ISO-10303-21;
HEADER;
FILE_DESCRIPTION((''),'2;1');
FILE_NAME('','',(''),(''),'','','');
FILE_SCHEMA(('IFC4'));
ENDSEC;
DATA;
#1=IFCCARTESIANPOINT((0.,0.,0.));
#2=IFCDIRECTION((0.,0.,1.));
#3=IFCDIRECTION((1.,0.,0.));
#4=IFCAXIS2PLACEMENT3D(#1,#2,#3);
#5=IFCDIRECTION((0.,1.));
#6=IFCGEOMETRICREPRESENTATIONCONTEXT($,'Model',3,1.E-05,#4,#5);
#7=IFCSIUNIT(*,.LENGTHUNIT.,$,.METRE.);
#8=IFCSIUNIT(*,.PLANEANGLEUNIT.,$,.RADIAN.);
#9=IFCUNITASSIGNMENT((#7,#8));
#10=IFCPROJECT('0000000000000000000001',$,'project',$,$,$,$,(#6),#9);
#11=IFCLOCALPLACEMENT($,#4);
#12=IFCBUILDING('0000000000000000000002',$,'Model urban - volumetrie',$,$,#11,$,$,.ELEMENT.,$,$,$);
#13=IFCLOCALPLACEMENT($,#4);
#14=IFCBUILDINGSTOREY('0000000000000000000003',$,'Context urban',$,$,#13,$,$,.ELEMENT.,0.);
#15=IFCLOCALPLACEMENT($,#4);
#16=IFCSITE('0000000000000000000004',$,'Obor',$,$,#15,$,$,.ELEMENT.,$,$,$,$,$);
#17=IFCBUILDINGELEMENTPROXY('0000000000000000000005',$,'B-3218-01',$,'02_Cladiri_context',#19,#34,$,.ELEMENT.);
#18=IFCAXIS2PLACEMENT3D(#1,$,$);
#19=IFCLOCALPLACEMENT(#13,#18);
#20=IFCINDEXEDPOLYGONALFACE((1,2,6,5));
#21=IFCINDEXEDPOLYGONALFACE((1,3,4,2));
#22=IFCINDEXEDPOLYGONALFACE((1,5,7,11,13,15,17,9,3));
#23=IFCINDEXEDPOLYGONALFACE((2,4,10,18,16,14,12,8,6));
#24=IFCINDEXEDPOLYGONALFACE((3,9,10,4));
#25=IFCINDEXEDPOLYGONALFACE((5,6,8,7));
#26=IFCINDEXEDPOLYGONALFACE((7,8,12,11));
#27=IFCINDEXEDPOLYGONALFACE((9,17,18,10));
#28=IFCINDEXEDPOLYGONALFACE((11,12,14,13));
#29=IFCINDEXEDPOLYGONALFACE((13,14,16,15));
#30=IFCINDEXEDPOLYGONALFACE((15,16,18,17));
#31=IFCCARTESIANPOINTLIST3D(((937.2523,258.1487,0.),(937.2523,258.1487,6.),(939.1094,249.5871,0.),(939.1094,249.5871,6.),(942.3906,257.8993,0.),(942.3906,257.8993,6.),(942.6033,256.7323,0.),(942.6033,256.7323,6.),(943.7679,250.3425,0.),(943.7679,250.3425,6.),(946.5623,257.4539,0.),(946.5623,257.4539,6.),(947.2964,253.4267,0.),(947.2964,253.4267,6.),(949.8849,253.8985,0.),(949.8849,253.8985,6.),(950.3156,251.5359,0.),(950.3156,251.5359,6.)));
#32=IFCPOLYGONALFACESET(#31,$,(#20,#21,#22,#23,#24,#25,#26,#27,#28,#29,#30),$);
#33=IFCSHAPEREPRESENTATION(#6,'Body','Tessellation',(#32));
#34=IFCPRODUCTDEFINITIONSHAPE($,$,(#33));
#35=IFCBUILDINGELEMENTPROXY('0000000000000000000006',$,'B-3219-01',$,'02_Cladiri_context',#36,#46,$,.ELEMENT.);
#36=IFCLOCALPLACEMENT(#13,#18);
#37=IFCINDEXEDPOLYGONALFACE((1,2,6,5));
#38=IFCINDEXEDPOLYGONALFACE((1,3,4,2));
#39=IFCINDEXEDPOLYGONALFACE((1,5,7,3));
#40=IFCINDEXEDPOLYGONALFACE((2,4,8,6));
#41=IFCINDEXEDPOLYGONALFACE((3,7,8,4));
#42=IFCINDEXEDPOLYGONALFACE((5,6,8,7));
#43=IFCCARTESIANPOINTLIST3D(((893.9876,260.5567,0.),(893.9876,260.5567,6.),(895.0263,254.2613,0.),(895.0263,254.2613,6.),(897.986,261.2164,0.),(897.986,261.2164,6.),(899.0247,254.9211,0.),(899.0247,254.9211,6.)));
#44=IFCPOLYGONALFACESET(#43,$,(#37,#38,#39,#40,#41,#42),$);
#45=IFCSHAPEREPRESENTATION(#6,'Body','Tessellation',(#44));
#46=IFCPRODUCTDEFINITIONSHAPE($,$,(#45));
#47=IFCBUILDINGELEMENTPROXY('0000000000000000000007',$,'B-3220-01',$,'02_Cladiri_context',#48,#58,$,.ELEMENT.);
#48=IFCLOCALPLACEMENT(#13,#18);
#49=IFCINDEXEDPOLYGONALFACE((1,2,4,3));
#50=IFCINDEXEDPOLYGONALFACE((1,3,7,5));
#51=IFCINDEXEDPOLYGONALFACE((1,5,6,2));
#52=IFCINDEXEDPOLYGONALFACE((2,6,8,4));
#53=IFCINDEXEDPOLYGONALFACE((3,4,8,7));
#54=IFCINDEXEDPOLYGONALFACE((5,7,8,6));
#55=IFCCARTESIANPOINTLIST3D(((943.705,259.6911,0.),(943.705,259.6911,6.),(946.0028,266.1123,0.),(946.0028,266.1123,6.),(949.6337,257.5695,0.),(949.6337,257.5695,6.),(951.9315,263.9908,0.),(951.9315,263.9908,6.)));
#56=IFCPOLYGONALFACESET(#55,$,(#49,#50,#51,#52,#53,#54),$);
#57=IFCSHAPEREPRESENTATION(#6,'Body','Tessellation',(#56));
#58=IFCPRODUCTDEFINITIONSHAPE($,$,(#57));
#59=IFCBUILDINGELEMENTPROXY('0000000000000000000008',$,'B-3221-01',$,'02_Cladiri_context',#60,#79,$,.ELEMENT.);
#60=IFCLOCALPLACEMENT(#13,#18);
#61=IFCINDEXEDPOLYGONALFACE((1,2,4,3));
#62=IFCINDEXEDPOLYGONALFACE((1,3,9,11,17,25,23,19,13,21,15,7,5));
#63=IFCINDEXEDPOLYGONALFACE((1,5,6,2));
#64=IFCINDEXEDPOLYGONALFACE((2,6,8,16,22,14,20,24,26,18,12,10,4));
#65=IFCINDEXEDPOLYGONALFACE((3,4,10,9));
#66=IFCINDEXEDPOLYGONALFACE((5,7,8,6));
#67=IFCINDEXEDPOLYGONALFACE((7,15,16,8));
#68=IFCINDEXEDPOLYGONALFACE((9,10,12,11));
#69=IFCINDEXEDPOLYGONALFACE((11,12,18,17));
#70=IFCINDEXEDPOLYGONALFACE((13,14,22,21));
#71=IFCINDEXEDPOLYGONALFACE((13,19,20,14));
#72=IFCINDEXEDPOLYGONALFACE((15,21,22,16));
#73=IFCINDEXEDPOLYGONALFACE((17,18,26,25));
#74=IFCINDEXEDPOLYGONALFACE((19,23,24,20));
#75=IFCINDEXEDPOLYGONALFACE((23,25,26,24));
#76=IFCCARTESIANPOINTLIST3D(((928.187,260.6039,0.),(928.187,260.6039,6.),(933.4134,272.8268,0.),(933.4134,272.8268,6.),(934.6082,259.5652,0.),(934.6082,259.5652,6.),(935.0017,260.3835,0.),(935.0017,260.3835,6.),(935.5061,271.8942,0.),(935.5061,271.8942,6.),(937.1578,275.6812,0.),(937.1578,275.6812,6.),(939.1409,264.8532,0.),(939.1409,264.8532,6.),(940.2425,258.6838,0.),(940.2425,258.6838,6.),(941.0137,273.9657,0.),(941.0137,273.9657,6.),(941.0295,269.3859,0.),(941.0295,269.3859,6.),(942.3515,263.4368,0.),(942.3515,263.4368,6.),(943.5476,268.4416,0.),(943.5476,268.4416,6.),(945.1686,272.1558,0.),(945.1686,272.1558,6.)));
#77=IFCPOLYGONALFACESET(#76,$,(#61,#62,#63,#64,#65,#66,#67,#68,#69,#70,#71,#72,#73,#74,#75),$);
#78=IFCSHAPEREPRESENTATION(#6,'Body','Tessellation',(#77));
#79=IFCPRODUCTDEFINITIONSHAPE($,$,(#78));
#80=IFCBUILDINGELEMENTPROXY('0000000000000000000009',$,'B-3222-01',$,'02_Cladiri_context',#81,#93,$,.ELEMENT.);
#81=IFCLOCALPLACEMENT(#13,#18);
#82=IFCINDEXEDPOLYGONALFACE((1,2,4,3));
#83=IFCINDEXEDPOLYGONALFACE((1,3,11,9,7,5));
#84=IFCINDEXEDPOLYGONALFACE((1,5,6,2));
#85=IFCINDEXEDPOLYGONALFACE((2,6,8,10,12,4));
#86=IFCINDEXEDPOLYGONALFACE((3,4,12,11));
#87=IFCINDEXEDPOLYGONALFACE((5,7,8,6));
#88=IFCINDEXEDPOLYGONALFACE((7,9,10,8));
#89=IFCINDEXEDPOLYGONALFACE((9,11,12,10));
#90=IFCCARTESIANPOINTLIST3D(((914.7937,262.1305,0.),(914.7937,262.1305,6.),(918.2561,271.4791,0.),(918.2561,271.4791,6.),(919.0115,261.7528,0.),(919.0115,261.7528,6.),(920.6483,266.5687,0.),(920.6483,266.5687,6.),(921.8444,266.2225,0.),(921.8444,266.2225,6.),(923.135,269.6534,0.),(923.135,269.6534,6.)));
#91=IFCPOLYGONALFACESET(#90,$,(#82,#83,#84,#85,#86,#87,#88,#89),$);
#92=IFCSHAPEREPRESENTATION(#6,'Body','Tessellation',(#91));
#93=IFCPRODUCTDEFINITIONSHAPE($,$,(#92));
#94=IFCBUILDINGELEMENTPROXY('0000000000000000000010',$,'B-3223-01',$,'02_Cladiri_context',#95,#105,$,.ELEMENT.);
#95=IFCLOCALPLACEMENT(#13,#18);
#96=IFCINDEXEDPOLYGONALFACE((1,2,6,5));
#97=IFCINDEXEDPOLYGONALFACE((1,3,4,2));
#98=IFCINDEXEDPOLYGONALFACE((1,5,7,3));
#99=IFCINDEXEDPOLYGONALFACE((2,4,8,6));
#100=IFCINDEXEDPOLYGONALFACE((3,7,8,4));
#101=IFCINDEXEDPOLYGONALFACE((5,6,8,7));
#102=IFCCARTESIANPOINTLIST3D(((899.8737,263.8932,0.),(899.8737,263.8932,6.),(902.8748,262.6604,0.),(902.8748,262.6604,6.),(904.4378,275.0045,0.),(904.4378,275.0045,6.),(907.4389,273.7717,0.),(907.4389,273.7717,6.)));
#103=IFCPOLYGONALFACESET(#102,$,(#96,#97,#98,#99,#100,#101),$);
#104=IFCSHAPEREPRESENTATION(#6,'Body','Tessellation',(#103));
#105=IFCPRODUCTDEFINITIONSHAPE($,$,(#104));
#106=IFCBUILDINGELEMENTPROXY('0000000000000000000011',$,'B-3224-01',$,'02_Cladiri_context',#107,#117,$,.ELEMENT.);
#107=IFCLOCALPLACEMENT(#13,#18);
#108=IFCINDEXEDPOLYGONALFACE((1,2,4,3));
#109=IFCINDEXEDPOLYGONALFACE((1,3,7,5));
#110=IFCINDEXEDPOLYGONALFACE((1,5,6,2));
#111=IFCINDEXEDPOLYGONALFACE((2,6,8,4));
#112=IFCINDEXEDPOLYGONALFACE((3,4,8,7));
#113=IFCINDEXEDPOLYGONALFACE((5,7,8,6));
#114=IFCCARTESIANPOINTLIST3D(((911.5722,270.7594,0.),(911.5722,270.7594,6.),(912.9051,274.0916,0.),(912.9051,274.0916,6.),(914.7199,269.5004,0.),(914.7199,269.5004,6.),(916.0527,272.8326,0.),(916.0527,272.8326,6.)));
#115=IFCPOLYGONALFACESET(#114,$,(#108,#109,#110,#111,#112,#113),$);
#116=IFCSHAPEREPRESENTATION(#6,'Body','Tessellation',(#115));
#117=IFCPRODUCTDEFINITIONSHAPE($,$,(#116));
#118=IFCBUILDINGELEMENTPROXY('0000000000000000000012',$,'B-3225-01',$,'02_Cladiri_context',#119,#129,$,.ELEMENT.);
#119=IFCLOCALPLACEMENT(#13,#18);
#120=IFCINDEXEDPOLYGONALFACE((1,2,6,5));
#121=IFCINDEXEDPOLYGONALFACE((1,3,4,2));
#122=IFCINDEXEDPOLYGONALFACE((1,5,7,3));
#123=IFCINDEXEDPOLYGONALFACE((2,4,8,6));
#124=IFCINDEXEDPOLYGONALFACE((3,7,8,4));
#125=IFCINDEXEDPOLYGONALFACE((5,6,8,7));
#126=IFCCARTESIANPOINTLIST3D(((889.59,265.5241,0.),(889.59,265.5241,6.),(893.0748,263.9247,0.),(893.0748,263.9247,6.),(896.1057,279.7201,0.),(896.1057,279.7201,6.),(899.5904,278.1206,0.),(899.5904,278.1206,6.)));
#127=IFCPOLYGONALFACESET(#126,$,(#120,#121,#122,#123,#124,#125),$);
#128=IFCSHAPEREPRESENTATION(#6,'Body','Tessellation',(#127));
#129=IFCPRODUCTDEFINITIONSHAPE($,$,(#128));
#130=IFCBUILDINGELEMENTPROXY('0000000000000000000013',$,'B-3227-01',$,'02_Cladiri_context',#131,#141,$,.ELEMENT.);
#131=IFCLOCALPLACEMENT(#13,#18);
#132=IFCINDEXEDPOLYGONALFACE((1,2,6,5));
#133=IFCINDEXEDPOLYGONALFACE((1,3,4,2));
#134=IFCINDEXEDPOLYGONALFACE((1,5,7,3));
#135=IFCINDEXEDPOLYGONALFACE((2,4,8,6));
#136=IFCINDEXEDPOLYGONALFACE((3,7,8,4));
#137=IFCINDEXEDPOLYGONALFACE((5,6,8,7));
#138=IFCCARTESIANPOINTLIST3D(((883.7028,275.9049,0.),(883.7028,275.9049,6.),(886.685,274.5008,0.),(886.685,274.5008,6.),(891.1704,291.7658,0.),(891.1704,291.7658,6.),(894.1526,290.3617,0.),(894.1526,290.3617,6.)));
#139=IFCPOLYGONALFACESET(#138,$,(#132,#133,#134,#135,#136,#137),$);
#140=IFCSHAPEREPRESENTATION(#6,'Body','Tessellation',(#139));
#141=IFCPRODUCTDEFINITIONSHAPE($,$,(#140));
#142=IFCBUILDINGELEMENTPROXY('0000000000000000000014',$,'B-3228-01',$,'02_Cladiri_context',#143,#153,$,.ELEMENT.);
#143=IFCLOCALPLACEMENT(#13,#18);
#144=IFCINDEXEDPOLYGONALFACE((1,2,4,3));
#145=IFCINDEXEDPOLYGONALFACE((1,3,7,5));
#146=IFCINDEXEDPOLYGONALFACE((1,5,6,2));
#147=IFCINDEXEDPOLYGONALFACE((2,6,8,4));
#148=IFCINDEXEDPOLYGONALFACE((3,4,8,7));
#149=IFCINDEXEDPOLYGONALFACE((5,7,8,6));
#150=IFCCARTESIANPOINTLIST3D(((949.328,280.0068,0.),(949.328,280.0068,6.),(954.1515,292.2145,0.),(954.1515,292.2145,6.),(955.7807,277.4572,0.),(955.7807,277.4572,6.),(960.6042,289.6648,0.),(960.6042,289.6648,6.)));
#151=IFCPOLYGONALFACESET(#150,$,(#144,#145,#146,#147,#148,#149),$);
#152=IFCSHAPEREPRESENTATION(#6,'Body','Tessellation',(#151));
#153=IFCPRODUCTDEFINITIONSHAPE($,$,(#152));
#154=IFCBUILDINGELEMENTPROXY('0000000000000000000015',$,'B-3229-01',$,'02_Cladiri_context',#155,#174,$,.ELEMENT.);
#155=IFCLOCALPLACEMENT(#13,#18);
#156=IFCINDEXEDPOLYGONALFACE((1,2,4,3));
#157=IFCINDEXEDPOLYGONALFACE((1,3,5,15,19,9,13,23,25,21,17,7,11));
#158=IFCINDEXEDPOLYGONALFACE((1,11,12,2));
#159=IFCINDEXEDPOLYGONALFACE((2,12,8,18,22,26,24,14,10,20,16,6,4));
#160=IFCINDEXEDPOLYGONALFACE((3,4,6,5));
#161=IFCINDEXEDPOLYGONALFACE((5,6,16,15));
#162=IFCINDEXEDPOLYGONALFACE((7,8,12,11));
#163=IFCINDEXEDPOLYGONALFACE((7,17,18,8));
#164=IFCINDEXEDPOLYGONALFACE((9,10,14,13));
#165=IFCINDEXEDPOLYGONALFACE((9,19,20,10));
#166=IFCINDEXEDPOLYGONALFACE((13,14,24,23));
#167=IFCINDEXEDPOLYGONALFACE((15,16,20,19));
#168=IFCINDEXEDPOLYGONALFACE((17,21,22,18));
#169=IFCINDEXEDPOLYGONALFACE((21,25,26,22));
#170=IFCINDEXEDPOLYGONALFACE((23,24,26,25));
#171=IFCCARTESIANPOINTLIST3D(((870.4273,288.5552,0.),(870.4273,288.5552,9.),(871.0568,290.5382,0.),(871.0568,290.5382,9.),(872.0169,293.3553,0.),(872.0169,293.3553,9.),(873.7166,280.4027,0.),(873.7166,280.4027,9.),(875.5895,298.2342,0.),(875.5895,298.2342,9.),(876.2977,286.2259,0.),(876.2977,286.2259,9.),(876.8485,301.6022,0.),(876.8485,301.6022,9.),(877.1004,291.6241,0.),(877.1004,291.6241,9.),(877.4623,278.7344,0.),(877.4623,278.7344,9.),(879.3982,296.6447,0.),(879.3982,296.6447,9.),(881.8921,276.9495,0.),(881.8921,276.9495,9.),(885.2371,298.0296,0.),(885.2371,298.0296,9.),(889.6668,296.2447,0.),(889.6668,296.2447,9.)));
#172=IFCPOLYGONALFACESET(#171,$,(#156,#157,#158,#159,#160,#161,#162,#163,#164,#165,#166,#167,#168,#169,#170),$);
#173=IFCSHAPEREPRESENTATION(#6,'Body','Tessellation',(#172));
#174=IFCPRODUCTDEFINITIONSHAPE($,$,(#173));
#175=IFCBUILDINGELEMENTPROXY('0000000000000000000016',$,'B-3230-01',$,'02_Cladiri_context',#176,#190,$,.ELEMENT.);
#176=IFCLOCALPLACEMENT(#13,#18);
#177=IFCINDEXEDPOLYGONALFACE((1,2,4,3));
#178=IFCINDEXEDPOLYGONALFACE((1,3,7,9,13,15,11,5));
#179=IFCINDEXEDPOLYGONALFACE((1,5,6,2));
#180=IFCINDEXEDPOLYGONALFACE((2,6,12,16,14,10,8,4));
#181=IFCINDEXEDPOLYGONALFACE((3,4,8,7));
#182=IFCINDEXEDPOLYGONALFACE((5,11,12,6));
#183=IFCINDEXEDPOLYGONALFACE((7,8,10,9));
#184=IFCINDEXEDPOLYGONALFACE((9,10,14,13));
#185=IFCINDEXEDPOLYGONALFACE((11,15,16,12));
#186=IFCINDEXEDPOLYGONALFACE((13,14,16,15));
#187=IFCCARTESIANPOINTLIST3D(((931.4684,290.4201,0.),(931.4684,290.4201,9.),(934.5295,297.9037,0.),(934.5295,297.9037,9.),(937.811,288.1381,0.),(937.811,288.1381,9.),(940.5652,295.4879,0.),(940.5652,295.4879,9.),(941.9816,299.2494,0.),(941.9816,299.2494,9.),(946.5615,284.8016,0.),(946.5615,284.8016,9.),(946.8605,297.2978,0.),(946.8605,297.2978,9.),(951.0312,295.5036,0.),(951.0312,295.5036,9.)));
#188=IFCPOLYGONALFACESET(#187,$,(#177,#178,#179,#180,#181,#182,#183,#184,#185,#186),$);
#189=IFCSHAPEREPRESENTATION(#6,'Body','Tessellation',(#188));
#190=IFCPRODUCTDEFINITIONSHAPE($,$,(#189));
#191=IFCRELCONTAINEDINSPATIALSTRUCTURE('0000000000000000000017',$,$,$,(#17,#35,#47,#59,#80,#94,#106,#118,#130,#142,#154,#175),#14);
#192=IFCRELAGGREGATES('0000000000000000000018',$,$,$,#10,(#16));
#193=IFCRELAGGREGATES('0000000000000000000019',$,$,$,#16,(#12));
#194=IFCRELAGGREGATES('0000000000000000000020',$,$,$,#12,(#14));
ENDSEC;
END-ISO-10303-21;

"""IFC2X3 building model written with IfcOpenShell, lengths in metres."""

from ifc_helpers import new_model, si_unit, direction, origin_with_axes, place, context, project, spatial, polyline, outline, extrude, element, save


model = new_model("IFC2X3")

# Units and contexts
model_context = context("Model", 3, precision=1e-05, world=origin_with_axes(), true_north=direction((0.0, 1.0)))
ifc_project = project(units=[si_unit("LENGTHUNIT", "METRE"), si_unit("PLANEANGLEUNIT", "RADIAN")], contexts=[model_context])

# Site, building, storey
site_placement = place(None, origin_with_axes())
site = spatial("IfcSite", under=ifc_project, at=site_placement, Name="Obor", CompositionType="ELEMENT")
building_placement = place(None, origin_with_axes())
building = spatial("IfcBuilding", under=site, at=building_placement, Name="Model urban - volumetrie", CompositionType="ELEMENT")
storey_placement = place(None, origin_with_axes())
storey = spatial("IfcBuildingStorey", under=building, at=storey_placement, Name="Context urban", CompositionType="ELEMENT", Elevation=0.0)

# Building element proxies
proxy_1_placement = place(None, origin_with_axes())
element("IfcBuildingElementProxy", 1, at=proxy_1_placement, inside=storey, Name="B-3218-01", ObjectType="02_Cladiri_context", CompositionType="ELEMENT", context=model_context, shape_type="SweptSolid", body=[
    extrude(outline(polyline([(946.5623, 257.4539), (942.6033, 256.7323), (942.3906, 257.8993), (937.2523, 258.1487), (939.1094, 249.5871), (943.7679, 250.3425), (950.3156, 251.5359), (949.8849, 253.8985), (947.2964, 253.4267), (946.5623, 257.4539)])), origin_with_axes(), (0.0, 0.0, 1.0), 6.0),
])
proxy_2_placement = place(None, origin_with_axes())
element("IfcBuildingElementProxy", 2, at=proxy_2_placement, inside=storey, Name="B-3219-01", ObjectType="02_Cladiri_context", CompositionType="ELEMENT", context=model_context, shape_type="SweptSolid", body=[
    extrude(outline(polyline([(899.0247, 254.9211), (897.986, 261.2164), (893.9876, 260.5567), (895.0263, 254.2613), (899.0247, 254.9211)])), origin_with_axes(), (0.0, 0.0, 1.0), 6.0),
])
proxy_3_placement = place(None, origin_with_axes())
element("IfcBuildingElementProxy", 3, at=proxy_3_placement, inside=storey, Name="B-3220-01", ObjectType="02_Cladiri_context", CompositionType="ELEMENT", context=model_context, shape_type="SweptSolid", body=[
    extrude(outline(polyline([(943.705, 259.6911), (949.6337, 257.5695), (951.9315, 263.9908), (946.0028, 266.1123), (943.705, 259.6911)])), origin_with_axes(), (0.0, 0.0, 1.0), 6.0),
])
proxy_4_placement = place(None, origin_with_axes())
element("IfcBuildingElementProxy", 4, at=proxy_4_placement, inside=storey, Name="B-3221-01", ObjectType="02_Cladiri_context", CompositionType="ELEMENT", context=model_context, shape_type="SweptSolid", body=[
    extrude(outline(polyline([(945.1686, 272.1558), (941.0137, 273.9657), (937.1578, 275.6812), (935.5061, 271.8942), (933.4134, 272.8268), (928.187, 260.6039), (934.6082, 259.5652), (935.0017, 260.3835), (940.2425, 258.6838), (942.3515, 263.4368), (939.1409, 264.8532), (941.0295, 269.3859), (943.5476, 268.4416), (945.1686, 272.1558)])), origin_with_axes(), (0.0, 0.0, 1.0), 6.0),
])
proxy_5_placement = place(None, origin_with_axes())
element("IfcBuildingElementProxy", 5, at=proxy_5_placement, inside=storey, Name="B-3222-01", ObjectType="02_Cladiri_context", CompositionType="ELEMENT", context=model_context, shape_type="SweptSolid", body=[
    extrude(outline(polyline([(921.8444, 266.2225), (923.135, 269.6534), (918.2561, 271.4791), (914.7937, 262.1305), (919.0115, 261.7528), (920.6483, 266.5687), (921.8444, 266.2225)])), origin_with_axes(), (0.0, 0.0, 1.0), 6.0),
])
proxy_6_placement = place(None, origin_with_axes())
element("IfcBuildingElementProxy", 6, at=proxy_6_placement, inside=storey, Name="B-3223-01", ObjectType="02_Cladiri_context", CompositionType="ELEMENT", context=model_context, shape_type="SweptSolid", body=[
    extrude(outline(polyline([(902.8748, 262.6604), (907.4389, 273.7717), (904.4378, 275.0045), (899.8737, 263.8932), (902.8748, 262.6604)])), origin_with_axes(), (0.0, 0.0, 1.0), 6.0),
])
proxy_7_placement = place(None, origin_with_axes())
element("IfcBuildingElementProxy", 7, at=proxy_7_placement, inside=storey, Name="B-3224-01", ObjectType="02_Cladiri_context", CompositionType="ELEMENT", context=model_context, shape_type="SweptSolid", body=[
    extrude(outline(polyline([(911.5722, 270.7594), (914.7199, 269.5004), (916.0527, 272.8326), (912.9051, 274.0916), (911.5722, 270.7594)])), origin_with_axes(), (0.0, 0.0, 1.0), 6.0),
])
proxy_8_placement = place(None, origin_with_axes())
element("IfcBuildingElementProxy", 8, at=proxy_8_placement, inside=storey, Name="B-3225-01", ObjectType="02_Cladiri_context", CompositionType="ELEMENT", context=model_context, shape_type="SweptSolid", body=[
    extrude(outline(polyline([(899.5904, 278.1206), (896.1057, 279.7201), (889.59, 265.5241), (893.0748, 263.9247), (899.5904, 278.1206)])), origin_with_axes(), (0.0, 0.0, 1.0), 6.0),
])
proxy_9_placement = place(None, origin_with_axes())
element("IfcBuildingElementProxy", 9, at=proxy_9_placement, inside=storey, Name="B-3227-01", ObjectType="02_Cladiri_context", CompositionType="ELEMENT", context=model_context, shape_type="SweptSolid", body=[
    extrude(outline(polyline([(883.7028, 275.9049), (886.685, 274.5008), (894.1526, 290.3617), (891.1704, 291.7658), (883.7028, 275.9049)])), origin_with_axes(), (0.0, 0.0, 1.0), 6.0),
])
proxy_10_placement = place(None, origin_with_axes())
element("IfcBuildingElementProxy", 10, at=proxy_10_placement, inside=storey, Name="B-3228-01", ObjectType="02_Cladiri_context", CompositionType="ELEMENT", context=model_context, shape_type="SweptSolid", body=[
    extrude(outline(polyline([(955.7807, 277.4572), (960.6042, 289.6648), (954.1515, 292.2145), (949.328, 280.0068), (955.7807, 277.4572)])), origin_with_axes(), (0.0, 0.0, 1.0), 6.0),
])
proxy_11_placement = place(None, origin_with_axes())
element("IfcBuildingElementProxy", 11, at=proxy_11_placement, inside=storey, Name="B-3229-01", ObjectType="02_Cladiri_context", CompositionType="ELEMENT", context=model_context, shape_type="SweptSolid", body=[
    extrude(outline(polyline([(877.4623, 278.7344), (881.8921, 276.9495), (889.6668, 296.2447), (885.2371, 298.0296), (876.8485, 301.6022), (875.5895, 298.2342), (879.3982, 296.6447), (877.1004, 291.6241), (872.0169, 293.3553), (871.0568, 290.5382), (870.4273, 288.5552), (876.2977, 286.2259), (873.7166, 280.4027), (877.4623, 278.7344)])), origin_with_axes(), (0.0, 0.0, 1.0), 9.0),
])
proxy_12_placement = place(None, origin_with_axes())
element("IfcBuildingElementProxy", 12, at=proxy_12_placement, inside=storey, Name="B-3230-01", ObjectType="02_Cladiri_context", CompositionType="ELEMENT", context=model_context, shape_type="SweptSolid", body=[
    extrude(outline(polyline([(937.811, 288.1381), (946.5615, 284.8016), (951.0312, 295.5036), (946.8605, 297.2978), (941.9816, 299.2494), (940.5652, 295.4879), (934.5295, 297.9037), (931.4684, 290.4201), (937.811, 288.1381)])), origin_with_axes(), (0.0, 0.0, 1.0), 9.0),
])

save(model, "model.ifc")
